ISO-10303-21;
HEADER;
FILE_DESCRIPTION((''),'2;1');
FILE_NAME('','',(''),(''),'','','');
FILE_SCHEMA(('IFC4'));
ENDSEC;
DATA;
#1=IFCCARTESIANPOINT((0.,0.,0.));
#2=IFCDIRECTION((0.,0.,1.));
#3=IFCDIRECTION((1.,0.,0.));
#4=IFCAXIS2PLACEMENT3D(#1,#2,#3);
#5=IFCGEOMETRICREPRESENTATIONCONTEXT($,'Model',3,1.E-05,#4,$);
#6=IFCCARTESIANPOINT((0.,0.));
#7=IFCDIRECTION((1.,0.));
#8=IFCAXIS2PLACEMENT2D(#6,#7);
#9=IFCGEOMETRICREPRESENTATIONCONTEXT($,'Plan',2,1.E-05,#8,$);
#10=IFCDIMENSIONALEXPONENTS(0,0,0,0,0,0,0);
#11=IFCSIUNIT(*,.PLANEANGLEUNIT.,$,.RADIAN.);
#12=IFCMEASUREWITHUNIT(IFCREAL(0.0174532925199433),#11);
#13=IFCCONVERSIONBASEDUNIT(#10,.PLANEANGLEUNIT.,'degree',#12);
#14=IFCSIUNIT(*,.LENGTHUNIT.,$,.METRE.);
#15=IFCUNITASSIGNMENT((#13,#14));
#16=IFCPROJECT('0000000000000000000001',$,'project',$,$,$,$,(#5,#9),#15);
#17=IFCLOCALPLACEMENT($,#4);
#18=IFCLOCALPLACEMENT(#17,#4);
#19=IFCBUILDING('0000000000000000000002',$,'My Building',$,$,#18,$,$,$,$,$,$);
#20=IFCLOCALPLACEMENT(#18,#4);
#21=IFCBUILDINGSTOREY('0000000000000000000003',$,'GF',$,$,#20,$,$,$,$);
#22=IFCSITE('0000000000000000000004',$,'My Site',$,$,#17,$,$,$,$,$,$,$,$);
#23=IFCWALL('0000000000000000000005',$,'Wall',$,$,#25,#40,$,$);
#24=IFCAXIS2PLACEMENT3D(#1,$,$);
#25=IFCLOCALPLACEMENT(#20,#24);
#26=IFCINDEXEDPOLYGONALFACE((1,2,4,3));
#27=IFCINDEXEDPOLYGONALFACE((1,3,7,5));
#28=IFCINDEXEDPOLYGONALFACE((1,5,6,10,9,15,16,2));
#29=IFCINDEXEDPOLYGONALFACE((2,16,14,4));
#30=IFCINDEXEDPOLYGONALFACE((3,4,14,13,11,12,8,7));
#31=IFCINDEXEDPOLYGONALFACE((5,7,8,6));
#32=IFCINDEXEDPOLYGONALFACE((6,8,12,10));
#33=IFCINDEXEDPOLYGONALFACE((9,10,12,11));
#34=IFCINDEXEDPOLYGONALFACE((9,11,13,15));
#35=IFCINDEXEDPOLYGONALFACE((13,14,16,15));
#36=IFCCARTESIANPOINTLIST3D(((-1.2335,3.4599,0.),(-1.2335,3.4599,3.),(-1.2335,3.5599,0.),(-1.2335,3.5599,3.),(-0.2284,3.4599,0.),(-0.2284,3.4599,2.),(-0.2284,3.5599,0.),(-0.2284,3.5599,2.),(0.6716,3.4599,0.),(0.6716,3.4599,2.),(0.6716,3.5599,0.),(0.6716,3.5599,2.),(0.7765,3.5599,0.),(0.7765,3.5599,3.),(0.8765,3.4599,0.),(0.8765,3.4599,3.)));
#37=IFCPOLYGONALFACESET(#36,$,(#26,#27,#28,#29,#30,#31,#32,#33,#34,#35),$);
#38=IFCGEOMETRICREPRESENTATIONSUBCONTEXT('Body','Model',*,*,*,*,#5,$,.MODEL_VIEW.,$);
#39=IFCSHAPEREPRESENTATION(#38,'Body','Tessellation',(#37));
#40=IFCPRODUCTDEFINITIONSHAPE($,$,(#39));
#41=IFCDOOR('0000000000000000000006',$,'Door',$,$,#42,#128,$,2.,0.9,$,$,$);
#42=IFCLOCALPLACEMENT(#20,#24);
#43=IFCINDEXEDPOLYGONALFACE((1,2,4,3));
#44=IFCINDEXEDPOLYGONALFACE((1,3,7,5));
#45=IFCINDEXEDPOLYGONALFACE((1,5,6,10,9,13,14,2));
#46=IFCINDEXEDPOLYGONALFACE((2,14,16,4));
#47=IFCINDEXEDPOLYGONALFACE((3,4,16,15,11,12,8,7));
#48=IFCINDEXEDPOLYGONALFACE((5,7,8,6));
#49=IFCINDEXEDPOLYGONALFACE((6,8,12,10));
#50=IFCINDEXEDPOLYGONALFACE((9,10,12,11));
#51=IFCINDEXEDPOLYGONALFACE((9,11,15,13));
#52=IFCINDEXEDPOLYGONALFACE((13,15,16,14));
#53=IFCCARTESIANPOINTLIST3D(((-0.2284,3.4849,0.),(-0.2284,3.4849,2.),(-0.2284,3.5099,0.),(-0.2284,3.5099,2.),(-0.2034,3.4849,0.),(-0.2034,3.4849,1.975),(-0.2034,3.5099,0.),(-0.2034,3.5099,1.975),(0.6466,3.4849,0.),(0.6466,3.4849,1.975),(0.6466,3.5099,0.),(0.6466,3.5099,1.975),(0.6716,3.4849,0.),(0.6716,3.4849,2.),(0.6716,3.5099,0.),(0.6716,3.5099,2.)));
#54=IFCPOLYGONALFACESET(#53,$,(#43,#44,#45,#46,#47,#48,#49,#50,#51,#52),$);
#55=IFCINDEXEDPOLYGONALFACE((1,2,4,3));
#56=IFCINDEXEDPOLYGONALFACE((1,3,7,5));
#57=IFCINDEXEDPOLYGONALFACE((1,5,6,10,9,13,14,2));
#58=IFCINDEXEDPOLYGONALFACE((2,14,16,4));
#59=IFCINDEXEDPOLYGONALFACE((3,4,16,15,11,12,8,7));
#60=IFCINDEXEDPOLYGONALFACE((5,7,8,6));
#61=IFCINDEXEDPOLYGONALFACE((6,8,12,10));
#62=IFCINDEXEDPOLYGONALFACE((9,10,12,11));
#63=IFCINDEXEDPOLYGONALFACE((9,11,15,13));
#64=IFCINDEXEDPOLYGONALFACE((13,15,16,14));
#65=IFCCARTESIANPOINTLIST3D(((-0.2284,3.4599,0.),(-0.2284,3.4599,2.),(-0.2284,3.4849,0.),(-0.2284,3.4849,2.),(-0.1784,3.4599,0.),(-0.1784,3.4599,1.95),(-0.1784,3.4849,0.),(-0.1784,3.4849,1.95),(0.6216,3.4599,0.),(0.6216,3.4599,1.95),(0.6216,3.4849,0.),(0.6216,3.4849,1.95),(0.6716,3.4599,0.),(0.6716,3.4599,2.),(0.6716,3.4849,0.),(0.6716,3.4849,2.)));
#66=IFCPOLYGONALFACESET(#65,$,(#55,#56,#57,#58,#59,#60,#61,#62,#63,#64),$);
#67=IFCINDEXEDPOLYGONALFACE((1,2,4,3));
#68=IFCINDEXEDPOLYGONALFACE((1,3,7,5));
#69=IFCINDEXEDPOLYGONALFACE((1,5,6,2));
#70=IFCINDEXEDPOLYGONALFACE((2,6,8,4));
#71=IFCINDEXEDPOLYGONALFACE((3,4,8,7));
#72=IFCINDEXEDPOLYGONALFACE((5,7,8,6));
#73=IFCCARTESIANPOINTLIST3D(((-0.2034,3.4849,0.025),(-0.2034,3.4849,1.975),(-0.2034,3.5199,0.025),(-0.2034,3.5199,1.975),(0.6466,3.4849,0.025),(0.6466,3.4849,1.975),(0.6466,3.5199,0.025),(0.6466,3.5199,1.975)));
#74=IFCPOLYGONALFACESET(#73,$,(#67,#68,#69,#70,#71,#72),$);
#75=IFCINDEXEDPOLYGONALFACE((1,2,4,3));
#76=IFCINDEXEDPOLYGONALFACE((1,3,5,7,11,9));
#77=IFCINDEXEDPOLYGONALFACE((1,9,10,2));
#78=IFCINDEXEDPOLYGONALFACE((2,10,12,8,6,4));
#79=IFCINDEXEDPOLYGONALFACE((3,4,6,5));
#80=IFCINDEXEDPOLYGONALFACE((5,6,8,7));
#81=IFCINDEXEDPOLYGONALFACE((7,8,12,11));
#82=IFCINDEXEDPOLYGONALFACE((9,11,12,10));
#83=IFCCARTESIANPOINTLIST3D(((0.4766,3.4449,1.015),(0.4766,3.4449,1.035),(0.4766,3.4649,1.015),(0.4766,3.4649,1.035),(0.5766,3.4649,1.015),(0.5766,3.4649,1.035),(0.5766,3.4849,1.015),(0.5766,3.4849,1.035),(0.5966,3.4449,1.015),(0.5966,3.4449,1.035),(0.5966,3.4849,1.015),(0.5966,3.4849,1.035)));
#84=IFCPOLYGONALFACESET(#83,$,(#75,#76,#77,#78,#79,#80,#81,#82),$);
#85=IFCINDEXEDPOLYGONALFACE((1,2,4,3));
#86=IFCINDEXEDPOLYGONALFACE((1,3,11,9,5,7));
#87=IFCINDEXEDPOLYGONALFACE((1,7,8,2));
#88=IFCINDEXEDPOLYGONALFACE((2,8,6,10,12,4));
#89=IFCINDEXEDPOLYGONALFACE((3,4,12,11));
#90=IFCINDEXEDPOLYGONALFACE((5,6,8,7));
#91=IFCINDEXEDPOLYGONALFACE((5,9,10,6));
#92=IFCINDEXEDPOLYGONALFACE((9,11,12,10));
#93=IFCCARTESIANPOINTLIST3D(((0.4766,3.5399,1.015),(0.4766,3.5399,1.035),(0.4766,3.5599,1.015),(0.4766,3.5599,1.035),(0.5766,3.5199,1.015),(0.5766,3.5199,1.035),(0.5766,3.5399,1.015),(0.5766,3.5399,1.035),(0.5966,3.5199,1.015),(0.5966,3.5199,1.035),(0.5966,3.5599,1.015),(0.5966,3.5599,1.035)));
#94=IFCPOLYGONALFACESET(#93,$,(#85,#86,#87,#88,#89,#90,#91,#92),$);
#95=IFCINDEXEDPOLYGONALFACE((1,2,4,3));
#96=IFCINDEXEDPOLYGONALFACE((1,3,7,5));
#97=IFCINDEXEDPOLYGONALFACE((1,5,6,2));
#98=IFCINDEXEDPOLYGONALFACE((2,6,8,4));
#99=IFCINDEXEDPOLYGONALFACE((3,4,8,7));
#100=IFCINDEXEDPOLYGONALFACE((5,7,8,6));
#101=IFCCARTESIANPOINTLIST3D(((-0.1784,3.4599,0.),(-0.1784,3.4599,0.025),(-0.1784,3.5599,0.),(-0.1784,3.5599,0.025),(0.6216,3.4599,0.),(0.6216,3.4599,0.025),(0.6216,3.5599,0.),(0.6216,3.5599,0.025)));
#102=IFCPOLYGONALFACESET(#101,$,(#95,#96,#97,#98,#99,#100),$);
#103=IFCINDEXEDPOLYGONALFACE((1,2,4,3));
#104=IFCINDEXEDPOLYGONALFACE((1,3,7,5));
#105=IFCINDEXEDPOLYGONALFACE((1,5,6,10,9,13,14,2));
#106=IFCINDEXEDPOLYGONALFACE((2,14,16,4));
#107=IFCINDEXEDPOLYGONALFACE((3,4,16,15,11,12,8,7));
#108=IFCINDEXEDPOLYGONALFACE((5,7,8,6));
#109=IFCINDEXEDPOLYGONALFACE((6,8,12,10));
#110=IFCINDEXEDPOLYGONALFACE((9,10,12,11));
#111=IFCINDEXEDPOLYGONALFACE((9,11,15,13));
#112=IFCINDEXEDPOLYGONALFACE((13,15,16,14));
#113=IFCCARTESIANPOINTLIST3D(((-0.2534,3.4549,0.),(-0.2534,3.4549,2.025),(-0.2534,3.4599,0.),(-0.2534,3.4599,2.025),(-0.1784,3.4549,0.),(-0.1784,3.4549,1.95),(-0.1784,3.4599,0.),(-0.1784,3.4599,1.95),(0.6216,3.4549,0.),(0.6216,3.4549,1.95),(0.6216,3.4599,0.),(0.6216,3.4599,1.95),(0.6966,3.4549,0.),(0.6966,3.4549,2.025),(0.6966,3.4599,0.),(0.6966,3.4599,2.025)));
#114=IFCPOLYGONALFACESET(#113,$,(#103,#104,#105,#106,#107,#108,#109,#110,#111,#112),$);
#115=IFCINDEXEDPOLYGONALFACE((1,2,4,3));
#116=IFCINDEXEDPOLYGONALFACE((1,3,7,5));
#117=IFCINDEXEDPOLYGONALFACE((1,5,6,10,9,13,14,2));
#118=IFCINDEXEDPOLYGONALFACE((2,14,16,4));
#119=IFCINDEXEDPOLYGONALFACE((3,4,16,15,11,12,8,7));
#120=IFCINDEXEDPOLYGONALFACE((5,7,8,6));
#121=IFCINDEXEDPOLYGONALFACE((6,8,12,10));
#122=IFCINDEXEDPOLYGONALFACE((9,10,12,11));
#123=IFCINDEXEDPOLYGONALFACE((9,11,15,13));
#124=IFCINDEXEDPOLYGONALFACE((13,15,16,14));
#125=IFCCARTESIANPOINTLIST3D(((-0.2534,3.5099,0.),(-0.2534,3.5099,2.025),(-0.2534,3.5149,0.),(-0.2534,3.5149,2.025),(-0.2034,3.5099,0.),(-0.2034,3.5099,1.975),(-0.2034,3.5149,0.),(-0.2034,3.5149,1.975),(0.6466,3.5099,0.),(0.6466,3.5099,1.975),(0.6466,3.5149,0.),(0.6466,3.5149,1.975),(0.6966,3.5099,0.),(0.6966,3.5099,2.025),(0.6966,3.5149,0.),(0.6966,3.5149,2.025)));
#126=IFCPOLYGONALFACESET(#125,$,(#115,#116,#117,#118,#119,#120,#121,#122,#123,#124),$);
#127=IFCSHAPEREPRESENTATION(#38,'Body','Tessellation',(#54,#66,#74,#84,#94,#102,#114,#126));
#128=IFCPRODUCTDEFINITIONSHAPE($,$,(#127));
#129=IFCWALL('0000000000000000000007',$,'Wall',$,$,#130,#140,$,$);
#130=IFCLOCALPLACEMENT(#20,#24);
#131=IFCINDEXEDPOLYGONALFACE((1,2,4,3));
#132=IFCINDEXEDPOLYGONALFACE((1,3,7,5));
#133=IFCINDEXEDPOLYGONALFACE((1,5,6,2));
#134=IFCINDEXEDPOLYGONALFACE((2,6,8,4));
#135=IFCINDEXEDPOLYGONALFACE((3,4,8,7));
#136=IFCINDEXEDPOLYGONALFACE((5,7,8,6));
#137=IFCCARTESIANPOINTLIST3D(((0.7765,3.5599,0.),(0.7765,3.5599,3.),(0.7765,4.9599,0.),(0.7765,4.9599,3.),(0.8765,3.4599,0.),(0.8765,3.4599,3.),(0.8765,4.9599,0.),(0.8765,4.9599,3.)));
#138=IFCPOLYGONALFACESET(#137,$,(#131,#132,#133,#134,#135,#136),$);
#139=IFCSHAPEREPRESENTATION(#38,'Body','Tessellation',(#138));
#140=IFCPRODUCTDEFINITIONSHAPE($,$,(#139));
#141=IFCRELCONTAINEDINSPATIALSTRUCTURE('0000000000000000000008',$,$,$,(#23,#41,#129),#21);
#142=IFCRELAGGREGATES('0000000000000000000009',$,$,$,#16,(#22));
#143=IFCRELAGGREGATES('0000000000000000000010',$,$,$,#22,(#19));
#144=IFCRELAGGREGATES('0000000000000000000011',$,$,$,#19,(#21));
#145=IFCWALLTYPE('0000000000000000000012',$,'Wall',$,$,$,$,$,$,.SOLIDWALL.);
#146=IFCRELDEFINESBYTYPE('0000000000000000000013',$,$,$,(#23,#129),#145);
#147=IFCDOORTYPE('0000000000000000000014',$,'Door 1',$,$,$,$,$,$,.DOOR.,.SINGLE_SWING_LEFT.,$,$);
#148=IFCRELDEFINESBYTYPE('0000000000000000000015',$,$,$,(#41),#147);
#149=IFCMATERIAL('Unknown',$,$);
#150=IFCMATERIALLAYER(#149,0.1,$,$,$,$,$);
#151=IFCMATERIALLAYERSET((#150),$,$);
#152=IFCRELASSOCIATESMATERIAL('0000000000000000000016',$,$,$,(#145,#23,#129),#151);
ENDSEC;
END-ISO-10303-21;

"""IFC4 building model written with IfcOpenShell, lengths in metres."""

from ifc_helpers import new_model, entity, si_unit, converted_unit, frame, origin_with_axes, origin_2d_with_axis, place, context, subcontext, project, spatial, line, indexed_curve, outline, extrude, shape, source, transform, mapped, material, layer, layer_set, layer_usage, type_object, type_shapes, element, fill, save


model = new_model("IFC4")

# Units and contexts
model_context = context("Model", 3, precision=1e-05, world=origin_with_axes())
plan_context = context("Plan", 2, precision=1e-05, world=origin_2d_with_axis())
body_context_1 = subcontext(model_context, "Body", "Model", "MODEL_VIEW")
body_context_2 = subcontext(plan_context, "Body", "Plan", "PLAN_VIEW")
ifc_project = project(units=[converted_unit("PLANEANGLEUNIT", "degree", entity("IfcReal", 0.0174532925199433), si_unit("PLANEANGLEUNIT", "RADIAN"), dimensions=[0, 0, 0, 0, 0, 0, 0]), si_unit("LENGTHUNIT", "METRE")], contexts=[model_context, plan_context])

# Site, building, storey
site_placement = place(None, origin_with_axes())
site = spatial("IfcSite", under=ifc_project, at=site_placement, Name="My Site")
building_placement = place(site_placement, origin_with_axes())
building = spatial("IfcBuilding", under=site, at=building_placement, Name="My Building")
storey_placement = place(building_placement, origin_with_axes())
storey = spatial("IfcBuildingStorey", under=building, at=storey_placement, Name="GF")

# Shared definitions
ifc_material = material(Name="Unknown")

# Shared definitions
ifc_layer_1 = layer(ifc_material, 0.1)
ifc_layer_set_1 = layer_set([ifc_layer_1])
wall_type = type_object("IfcWallType", Name="Wall", PredefinedType="SOLIDWALL", material=ifc_layer_set_1)
shared_shape_1 = source(origin_with_axes(), body_context_1, "Body", "SweptSolid", [
    extrude(outline(indexed_curve([(0.0, 0.0), (0.9, 0.0), (0.9, 2.0), (0.0, 2.0)], segments=[line(1, 2, 3, 4, 1)])), frame((0.0, -0.6, 0.0), z_axis=(0.0, -1.0, 0.0), x_axis=(1.0, 0.0, 0.0)), (0.0, 0.0, -1.0), 1.2),
])
door_type = type_object("IfcDoorType", Name="Door 1", OperationType="SINGLE_SWING_LEFT", PredefinedType="DOOR")
shared_shape_2 = source(origin_with_axes(), body_context_1, "Body", "SweptSolid", [
    extrude(outline(indexed_curve([(0.0, 0.0), (0.0, 2.0), (0.9, 2.0), (0.9, 0.0), (0.875, 0.0), (0.875, 1.975), (0.025, 1.975), (0.025, 0.0)], segments=[line(1, 2, 3, 4, 5, 6, 7, 8, 1)])), frame((0.0, 0.025, 0.0), z_axis=(0.0, -1.0, 0.0), x_axis=(1.0, 0.0, 0.0)), (0.0, 0.0, -1.0), 0.025),
    extrude(outline(indexed_curve([(0.0, 0.0), (0.0, 2.0), (0.9, 2.0), (0.9, 0.0), (0.85, 0.0), (0.85, 1.95), (0.05, 1.95), (0.05, 0.0)], segments=[line(1, 2, 3, 4, 5, 6, 7, 8, 1)])), frame((0.0, 0.0, 0.0), z_axis=(0.0, -1.0, 0.0), x_axis=(1.0, 0.0, 0.0)), (0.0, 0.0, -1.0), 0.025),
    extrude(outline(indexed_curve([(0.0, 0.0), (0.85, 0.0), (0.85, 0.035), (0.0, 0.035)], segments=[line(1, 2, 3, 4, 1)])), frame((0.025, 0.025, 0.025), z_axis=(0.0, 0.0, 1.0), x_axis=(1.0, 0.0, 0.0)), (0.0, 0.0, 1.0), 1.95),
    extrude(outline(indexed_curve([(0.0, 0.0), (0.0, -0.04), (-0.12, -0.04), (-0.12, -0.02), (-0.02, -0.02), (-0.02, 0.0)], segments=[line(1, 2, 3, 4, 5, 6, 1)])), frame((0.825, 0.025, 1.015), z_axis=(0.0, 0.0, 1.0), x_axis=(1.0, 0.0, 0.0)), (0.0, 0.0, 1.0), 0.02),
    extrude(outline(indexed_curve([(0.0, 0.0), (0.0, 0.04), (-0.12, 0.04), (-0.12, 0.02), (-0.02, 0.02), (-0.02, 0.0)], segments=[line(1, 2, 3, 4, 5, 6, 1)])), frame((0.825, 0.06, 1.015), z_axis=(0.0, 0.0, 1.0), x_axis=(1.0, 0.0, 0.0)), (0.0, 0.0, 1.0), 0.02),
    extrude(outline(indexed_curve([(0.0, 0.0), (0.8, 0.0), (0.8, 0.1), (0.0, 0.1)], segments=[line(1, 2, 3, 4, 1)])), frame((0.05, 0.0, 0.0), z_axis=(0.0, 0.0, 1.0), x_axis=(1.0, 0.0, 0.0)), (0.0, 0.0, 1.0), 0.025),
    extrude(outline(indexed_curve([(0.0, 0.0), (0.0, 2.025), (0.95, 2.025), (0.95, 0.0), (0.875, 0.0), (0.875, 1.95), (0.075, 1.95), (0.075, 0.0)], segments=[line(1, 2, 3, 4, 5, 6, 7, 8, 1)])), frame((-0.025, -0.005, 0.0), z_axis=(0.0, -1.0, 0.0), x_axis=(1.0, 0.0, 0.0)), (0.0, 0.0, -1.0), 0.005),
    extrude(outline(indexed_curve([(0.0, 0.0), (0.0, 2.025), (0.95, 2.025), (0.95, 0.0), (0.9, 0.0), (0.9, 1.975), (0.05, 1.975), (0.05, 0.0)], segments=[line(1, 2, 3, 4, 5, 6, 7, 8, 1)])), frame((-0.025, 0.05, 0.0), z_axis=(0.0, -1.0, 0.0), x_axis=(1.0, 0.0, 0.0)), (0.0, 0.0, -1.0), 0.005),
])
shared_shape_3 = source(origin_with_axes(), body_context_2, "Body", "Curve2D", [
    entity("IfcIndexedPolyCurve", entity("IfcCartesianPointList2D", [[0.0, 0.0], [0.0, 0.05], [0.025, 0.05], [0.025, 0.025], [0.05, 0.025], [0.05, 0.0]]), [entity("IfcLineIndex", [1, 2, 3, 4, 5, 6, 1])]),
    entity("IfcIndexedPolyCurve", entity("IfcCartesianPointList2D", [[0.9, 0.0], [0.9, 0.05], [0.875, 0.05], [0.875, 0.025], [0.85, 0.025], [0.85, 0.0]]), [entity("IfcLineIndex", [1, 2, 3, 4, 5, 6, 1])]),
    entity("IfcTrimmedCurve", entity("IfcEllipse", entity("IfcAxis2Placement2D", entity("IfcCartesianPoint", [0.06, 0.05]), entity("IfcDirection", [1.0, 0.0])), 0.815, 0.85), [entity("IfcCartesianPoint", [0.875, 0.05])], [entity("IfcCartesianPoint", [0.06, 0.9])], True, "CARTESIAN"),
    entity("IfcIndexedPolyCurve", entity("IfcCartesianPointList2D", [[0.025, 0.05], [0.06, 0.05], [0.06, 0.9], [0.025, 0.9]]), [entity("IfcLineIndex", [1, 2, 3, 4, 1])]),
])
type_shapes(door_type, [shared_shape_2, shared_shape_3])

# Wall, opening, door
ifc_layer_usage_1 = layer_usage(ifc_layer_set_1, "AXIS2", "POSITIVE", 0.0)
wall_1_placement = place(storey_placement, frame((-1.2335, 3.4599, 0.0), z_axis=(0.0, 0.0, 1.0), x_axis=(1.0, 0.0, 0.0)))
wall_1 = element("IfcWall", 1, at=wall_1_placement, inside=storey, type_object=wall_type, material=ifc_layer_usage_1, Name="Wall", context=body_context_1, shape_type="SweptSolid", body=[
    extrude(outline(indexed_curve([(0.0, 0.0), (0.0, 0.1), (2.01, 0.1), (2.11, 0.0)], segments=[line(1, 2, 3, 4, 1)])), origin_with_axes(), (0.0, 0.0, 1.0), 3.0),
])
opening_1_placement = place(wall_1_placement, frame((1.0051, 0.0, 0.0), z_axis=(0.0, 0.0, 1.0), x_axis=(1.0, 0.0, 0.0)))
opening_1 = element("IfcOpeningElement", 2, at=opening_1_placement, cuts=wall_1, PredefinedType="OPENING", context=body_context_1, shape_type="MappedRepresentation", body=[
    mapped(shared_shape_1, transform((0.0, 0.0, 0.0), x_axis=(1.0, 0.0, 0.0), y_axis=(0.0, 1.0, 0.0), z_axis=(0.0, 0.0, 1.0), scale=1.0)),
])
door_1_placement = place(opening_1_placement, origin_with_axes())
door_1 = element("IfcDoor", 3, at=door_1_placement, inside=storey, type_object=door_type, Name="Door", OverallHeight=2.0, OverallWidth=0.9, shapes=[
    shape(body_context_1, "Body", "MappedRepresentation", [mapped(shared_shape_2, transform((0.0, 0.0, 0.0), x_axis=(1.0, 0.0, 0.0), y_axis=(0.0, 1.0, 0.0), z_axis=(0.0, 0.0, 1.0), scale=1.0))]),
    shape(body_context_2, "Body", "MappedRepresentation", [mapped(shared_shape_3, transform((0.0, 0.0, 0.0), x_axis=(1.0, 0.0, 0.0), y_axis=(0.0, 1.0, 0.0), z_axis=(0.0, 0.0, 1.0), scale=1.0))]),
])
fill(opening_1, door_1)

# Wall
ifc_layer_usage_2 = layer_usage(ifc_layer_set_1, "AXIS2", "POSITIVE", 0.0)
wall_2_placement = place(storey_placement, frame((0.8765, 3.4599, 0.0), z_axis=(0.0, 0.0, 1.0), x_axis=(0.0, 1.0, 0.0)))
element("IfcWall", 4, at=wall_2_placement, inside=storey, type_object=wall_type, material=ifc_layer_usage_2, Name="Wall", context=body_context_1, shape_type="SweptSolid", body=[
    extrude(outline(indexed_curve([(0.0, 0.0), (0.1, 0.1), (1.5, 0.1), (1.5, 0.0)], segments=[line(1, 2, 3, 4, 1)])), origin_with_axes(), (0.0, 0.0, 1.0), 3.0),
])

save(model, "model.ifc")
